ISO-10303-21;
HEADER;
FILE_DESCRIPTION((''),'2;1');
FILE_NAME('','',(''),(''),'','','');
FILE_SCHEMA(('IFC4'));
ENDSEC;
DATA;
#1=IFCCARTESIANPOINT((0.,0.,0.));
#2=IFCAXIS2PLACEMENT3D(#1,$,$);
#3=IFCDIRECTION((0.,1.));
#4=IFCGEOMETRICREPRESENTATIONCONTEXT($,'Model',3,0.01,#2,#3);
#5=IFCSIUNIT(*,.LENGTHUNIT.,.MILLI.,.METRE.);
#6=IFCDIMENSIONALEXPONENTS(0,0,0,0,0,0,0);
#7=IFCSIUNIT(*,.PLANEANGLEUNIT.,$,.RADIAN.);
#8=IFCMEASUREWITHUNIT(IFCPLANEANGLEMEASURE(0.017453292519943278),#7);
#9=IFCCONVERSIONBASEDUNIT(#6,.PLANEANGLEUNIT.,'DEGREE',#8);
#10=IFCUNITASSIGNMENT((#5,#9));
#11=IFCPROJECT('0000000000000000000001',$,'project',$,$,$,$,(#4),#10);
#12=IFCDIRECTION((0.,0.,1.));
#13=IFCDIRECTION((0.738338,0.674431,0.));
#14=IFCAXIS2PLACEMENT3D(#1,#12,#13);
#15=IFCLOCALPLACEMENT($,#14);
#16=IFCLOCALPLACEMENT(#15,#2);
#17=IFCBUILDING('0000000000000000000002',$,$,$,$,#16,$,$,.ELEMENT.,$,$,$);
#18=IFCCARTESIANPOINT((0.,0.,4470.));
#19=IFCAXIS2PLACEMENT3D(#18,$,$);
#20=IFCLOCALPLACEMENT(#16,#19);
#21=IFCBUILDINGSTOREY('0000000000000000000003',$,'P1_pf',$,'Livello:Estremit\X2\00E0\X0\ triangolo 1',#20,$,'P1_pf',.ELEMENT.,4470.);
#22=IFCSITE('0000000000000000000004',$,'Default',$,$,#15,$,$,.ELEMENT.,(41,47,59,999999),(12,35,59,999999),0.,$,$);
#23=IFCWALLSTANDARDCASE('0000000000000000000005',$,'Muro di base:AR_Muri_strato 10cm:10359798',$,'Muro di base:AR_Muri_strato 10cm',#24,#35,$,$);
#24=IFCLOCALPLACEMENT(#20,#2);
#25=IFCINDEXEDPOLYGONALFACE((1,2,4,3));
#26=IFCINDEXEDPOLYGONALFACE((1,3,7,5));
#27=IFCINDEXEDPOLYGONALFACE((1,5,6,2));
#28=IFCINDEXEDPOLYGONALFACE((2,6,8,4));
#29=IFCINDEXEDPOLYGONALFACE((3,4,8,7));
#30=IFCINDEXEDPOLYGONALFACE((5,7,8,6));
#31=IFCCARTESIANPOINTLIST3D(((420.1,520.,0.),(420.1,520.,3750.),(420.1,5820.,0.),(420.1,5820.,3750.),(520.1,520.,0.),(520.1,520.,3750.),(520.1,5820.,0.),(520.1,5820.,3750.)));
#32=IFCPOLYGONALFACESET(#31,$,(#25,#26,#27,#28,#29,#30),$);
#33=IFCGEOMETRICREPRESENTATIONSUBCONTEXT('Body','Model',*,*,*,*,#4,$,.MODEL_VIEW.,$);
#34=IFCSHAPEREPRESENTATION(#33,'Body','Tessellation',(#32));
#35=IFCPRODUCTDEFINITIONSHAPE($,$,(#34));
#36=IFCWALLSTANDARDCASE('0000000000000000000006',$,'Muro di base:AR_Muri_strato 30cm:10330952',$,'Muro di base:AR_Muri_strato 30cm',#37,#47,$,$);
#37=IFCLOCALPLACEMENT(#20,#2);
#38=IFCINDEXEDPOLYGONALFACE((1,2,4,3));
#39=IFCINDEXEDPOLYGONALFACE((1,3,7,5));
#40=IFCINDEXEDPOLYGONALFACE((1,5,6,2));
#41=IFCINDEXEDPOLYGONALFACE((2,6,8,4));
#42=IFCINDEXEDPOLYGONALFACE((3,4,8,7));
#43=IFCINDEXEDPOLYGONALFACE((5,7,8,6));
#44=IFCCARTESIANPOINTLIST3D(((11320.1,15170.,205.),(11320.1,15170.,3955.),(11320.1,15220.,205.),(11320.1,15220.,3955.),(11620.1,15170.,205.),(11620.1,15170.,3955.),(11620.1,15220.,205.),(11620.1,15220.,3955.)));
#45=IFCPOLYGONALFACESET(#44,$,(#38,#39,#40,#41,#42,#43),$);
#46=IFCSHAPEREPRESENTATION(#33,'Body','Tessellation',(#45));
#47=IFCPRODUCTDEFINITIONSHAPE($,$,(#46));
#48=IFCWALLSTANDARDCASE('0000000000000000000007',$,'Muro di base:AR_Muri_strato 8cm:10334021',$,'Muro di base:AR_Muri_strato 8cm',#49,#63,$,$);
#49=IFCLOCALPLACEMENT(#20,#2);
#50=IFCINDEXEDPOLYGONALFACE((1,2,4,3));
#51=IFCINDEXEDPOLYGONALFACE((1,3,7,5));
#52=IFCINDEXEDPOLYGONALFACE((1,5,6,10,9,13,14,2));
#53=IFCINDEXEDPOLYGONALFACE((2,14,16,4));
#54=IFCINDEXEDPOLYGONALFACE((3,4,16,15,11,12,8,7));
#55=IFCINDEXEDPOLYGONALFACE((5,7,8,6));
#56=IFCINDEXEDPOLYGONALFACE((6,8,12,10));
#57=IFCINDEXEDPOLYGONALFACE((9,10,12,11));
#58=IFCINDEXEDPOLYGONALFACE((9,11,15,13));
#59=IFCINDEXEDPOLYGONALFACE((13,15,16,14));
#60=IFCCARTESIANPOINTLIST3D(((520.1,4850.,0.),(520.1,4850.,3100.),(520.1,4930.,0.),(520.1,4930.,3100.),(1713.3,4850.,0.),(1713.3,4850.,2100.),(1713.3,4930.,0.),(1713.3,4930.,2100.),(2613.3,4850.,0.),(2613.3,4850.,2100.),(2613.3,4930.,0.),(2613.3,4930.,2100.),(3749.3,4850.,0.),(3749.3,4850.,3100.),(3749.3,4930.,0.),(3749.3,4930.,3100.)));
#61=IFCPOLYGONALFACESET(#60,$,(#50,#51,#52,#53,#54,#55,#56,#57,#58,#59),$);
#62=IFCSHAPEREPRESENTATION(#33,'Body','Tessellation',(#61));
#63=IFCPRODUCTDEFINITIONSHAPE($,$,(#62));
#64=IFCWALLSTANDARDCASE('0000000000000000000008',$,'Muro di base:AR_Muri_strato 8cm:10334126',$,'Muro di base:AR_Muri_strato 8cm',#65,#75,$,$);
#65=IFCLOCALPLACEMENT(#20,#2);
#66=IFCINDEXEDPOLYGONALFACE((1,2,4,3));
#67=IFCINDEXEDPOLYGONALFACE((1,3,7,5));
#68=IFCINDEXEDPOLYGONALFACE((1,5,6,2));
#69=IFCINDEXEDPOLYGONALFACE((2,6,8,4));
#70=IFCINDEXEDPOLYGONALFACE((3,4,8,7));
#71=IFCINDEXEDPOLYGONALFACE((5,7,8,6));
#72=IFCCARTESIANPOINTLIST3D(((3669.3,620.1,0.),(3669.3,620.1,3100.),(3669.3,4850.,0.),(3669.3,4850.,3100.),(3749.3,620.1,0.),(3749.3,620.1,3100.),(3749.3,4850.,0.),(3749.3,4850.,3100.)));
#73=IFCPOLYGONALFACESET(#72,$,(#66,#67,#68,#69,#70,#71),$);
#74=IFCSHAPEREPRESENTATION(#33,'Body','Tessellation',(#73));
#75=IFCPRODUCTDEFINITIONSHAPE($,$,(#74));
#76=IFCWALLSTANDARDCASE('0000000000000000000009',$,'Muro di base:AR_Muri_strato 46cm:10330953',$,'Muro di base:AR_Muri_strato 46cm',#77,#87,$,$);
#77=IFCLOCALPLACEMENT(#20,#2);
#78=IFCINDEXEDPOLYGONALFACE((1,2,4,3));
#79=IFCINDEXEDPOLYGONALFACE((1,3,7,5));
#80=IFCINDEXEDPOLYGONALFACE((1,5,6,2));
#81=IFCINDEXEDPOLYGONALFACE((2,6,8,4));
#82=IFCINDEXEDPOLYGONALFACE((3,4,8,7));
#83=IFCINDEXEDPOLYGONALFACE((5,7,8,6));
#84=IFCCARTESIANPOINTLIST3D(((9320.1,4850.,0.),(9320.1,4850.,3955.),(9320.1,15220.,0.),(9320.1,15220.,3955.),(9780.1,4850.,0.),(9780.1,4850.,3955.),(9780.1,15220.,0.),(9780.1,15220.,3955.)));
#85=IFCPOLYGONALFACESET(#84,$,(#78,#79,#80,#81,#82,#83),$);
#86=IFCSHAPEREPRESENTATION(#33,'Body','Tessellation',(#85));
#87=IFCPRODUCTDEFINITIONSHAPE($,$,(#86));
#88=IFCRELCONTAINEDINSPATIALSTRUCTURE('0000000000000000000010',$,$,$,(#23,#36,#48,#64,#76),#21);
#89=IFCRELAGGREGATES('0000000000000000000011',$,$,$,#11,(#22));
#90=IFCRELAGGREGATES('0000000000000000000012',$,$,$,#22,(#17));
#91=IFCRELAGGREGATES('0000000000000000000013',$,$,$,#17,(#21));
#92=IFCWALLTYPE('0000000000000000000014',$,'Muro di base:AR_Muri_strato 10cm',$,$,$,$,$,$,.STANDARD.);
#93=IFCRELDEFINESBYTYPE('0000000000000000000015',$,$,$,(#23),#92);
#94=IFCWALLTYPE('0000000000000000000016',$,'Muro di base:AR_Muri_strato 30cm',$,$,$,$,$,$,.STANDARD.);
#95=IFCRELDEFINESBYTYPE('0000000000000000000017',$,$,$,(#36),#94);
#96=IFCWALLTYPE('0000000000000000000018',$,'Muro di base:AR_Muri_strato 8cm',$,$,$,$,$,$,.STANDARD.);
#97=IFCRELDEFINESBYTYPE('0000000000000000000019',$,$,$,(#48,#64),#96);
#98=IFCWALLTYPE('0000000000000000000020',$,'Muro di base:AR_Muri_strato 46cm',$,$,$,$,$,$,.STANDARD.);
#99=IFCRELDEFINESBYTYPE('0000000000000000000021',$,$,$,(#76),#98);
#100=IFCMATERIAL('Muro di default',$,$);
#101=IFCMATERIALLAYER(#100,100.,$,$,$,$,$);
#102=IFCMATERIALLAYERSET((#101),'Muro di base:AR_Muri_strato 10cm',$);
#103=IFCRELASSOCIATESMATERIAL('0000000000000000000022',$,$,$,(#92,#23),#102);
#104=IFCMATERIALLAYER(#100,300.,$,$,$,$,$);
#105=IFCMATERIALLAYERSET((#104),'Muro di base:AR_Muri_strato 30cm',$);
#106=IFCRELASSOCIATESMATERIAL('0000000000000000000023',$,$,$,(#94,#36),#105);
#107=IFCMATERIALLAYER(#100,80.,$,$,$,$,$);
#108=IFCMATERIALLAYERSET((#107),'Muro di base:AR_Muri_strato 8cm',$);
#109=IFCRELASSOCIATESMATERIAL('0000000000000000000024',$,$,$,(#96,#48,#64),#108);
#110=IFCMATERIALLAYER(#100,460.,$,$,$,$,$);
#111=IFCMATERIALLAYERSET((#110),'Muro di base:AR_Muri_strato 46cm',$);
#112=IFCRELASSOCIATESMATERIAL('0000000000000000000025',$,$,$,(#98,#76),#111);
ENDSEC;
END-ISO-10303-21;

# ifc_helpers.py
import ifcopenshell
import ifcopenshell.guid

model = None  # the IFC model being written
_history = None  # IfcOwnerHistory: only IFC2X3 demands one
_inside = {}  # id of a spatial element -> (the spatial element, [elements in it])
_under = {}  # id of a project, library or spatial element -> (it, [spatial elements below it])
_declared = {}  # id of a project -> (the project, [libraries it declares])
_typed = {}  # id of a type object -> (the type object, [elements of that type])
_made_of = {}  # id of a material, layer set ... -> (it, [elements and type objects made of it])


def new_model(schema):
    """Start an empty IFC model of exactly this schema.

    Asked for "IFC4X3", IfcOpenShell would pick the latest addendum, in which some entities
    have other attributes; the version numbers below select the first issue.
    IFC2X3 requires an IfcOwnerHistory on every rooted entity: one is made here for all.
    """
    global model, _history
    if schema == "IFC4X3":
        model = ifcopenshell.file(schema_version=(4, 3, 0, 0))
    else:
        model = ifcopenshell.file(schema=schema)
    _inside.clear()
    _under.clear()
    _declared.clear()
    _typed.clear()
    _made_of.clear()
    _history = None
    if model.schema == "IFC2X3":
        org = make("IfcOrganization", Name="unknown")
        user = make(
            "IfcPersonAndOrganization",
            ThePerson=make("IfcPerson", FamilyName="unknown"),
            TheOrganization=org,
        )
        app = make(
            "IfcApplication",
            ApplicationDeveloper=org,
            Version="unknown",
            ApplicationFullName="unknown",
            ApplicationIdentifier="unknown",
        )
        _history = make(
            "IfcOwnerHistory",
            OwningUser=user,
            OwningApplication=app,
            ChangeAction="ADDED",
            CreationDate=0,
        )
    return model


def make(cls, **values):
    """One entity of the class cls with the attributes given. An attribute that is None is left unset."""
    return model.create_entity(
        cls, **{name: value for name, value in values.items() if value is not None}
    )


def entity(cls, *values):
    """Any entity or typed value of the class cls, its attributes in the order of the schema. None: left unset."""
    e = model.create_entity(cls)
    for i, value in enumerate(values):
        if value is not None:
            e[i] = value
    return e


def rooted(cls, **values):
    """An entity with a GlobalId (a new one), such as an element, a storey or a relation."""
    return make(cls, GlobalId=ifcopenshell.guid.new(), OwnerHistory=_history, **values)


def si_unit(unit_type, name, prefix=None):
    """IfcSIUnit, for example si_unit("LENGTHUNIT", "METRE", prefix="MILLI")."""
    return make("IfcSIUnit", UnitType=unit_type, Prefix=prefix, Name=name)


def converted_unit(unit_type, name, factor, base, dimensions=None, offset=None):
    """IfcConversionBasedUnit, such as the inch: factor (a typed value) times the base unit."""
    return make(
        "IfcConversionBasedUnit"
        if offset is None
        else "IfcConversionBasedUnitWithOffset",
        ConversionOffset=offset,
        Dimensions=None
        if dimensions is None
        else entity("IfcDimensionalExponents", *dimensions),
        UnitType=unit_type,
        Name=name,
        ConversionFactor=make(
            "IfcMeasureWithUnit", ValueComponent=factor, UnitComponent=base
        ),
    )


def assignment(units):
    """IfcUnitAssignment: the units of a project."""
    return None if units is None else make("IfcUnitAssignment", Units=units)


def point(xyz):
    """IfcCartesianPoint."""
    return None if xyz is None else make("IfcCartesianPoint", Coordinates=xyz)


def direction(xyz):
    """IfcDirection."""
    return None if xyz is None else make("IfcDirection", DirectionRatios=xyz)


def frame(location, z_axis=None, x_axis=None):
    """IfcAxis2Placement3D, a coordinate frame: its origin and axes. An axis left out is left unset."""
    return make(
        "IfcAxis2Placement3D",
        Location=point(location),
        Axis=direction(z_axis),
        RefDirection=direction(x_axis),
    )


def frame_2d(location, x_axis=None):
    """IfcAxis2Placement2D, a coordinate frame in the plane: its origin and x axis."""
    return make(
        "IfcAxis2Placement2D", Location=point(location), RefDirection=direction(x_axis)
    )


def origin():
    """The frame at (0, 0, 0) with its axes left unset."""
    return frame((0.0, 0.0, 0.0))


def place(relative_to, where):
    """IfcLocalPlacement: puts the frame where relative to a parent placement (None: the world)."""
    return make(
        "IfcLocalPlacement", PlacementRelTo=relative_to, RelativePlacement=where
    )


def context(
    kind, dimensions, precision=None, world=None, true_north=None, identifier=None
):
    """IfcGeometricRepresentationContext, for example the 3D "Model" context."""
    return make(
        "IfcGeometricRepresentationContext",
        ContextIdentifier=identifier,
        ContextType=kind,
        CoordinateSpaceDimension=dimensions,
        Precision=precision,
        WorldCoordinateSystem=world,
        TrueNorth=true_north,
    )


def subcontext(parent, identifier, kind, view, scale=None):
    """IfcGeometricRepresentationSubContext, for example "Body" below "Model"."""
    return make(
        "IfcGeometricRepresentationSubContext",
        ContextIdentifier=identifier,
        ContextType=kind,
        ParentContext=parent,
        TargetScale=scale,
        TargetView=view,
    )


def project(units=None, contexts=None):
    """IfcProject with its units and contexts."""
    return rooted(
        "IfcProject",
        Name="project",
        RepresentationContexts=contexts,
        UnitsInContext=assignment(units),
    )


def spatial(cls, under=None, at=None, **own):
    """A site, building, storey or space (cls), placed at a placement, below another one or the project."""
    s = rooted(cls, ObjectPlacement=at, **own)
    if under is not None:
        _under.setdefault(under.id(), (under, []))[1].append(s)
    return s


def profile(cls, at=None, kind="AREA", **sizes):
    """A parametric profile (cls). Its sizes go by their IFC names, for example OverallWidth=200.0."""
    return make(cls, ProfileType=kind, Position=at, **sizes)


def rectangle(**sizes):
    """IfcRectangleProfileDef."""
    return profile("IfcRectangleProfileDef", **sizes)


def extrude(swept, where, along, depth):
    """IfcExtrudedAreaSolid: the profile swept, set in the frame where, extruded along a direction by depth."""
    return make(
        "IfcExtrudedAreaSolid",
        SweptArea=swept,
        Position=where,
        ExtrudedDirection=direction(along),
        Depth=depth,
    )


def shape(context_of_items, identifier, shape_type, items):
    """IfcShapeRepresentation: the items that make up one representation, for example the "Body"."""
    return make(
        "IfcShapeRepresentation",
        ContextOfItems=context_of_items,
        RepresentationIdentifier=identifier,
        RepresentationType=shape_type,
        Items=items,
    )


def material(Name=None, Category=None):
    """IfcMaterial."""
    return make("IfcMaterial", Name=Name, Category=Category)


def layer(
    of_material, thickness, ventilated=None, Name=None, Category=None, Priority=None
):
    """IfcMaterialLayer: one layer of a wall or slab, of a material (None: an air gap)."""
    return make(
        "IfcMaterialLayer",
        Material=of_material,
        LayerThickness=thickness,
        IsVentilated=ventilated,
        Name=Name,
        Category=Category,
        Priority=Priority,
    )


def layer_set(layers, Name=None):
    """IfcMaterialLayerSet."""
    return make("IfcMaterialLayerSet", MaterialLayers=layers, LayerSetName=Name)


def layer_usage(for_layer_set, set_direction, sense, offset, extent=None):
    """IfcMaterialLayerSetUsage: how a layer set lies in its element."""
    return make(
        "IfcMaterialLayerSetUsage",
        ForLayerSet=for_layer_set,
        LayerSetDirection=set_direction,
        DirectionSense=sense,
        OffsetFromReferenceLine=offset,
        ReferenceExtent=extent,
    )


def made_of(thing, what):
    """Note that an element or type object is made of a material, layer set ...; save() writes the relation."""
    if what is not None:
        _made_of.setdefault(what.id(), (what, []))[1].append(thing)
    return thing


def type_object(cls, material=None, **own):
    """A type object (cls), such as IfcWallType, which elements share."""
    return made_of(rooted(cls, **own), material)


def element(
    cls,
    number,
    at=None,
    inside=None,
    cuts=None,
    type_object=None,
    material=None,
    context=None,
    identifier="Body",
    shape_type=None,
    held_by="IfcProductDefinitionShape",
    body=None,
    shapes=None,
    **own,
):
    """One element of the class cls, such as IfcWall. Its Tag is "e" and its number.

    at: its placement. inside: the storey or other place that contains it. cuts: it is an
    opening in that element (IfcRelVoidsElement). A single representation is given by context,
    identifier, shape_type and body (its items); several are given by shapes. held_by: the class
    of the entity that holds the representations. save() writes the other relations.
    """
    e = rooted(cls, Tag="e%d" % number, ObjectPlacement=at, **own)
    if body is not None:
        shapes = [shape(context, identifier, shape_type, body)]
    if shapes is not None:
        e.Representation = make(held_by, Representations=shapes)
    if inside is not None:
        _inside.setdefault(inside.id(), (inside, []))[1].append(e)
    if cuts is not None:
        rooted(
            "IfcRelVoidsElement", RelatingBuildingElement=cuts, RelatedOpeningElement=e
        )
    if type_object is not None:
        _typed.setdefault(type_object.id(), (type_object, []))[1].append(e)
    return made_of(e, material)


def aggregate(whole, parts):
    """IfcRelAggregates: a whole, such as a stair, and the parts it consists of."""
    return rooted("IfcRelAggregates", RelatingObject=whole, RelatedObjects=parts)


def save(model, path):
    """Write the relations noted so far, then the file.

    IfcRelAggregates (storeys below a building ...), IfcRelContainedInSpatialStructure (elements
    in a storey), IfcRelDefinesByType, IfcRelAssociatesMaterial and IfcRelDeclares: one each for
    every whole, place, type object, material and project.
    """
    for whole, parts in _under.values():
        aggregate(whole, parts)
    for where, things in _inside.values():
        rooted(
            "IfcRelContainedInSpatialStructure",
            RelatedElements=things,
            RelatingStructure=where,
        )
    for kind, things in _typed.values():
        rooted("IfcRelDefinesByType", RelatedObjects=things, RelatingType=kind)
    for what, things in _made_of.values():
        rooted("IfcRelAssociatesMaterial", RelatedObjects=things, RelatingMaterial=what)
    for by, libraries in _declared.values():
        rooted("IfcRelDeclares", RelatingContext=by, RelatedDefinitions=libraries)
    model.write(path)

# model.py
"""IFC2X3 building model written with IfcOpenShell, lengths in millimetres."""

from ifc_helpers import new_model, entity, si_unit, converted_unit, direction, frame, frame_2d, origin, place, context, subcontext, project, spatial, rectangle, extrude, material, layer, layer_set, layer_usage, type_object, element, save


model = new_model("IFC2X3")

# Units and contexts
model_context = context("Model", 3, precision=0.01, world=origin(), true_north=direction((0.0, 1.0)))
body_context = subcontext(model_context, "Body", "Model", "MODEL_VIEW")
ifc_project = project(units=[si_unit("LENGTHUNIT", "METRE", prefix="MILLI"), converted_unit("PLANEANGLEUNIT", "DEGREE", entity("IfcPlaneAngleMeasure", 0.017453292519943278), si_unit("PLANEANGLEUNIT", "RADIAN"), dimensions=[0, 0, 0, 0, 0, 0, 0])], contexts=[model_context])

# Site, building, storey
site_placement = place(None, frame((0.0, 0.0, 0.0), z_axis=(0.0, 0.0, 1.0), x_axis=(0.738338, 0.674431, 0.0)))
site = spatial("IfcSite", under=ifc_project, at=site_placement, Name="Default", CompositionType="ELEMENT", RefLatitude=(41, 47, 59, 999999), RefLongitude=(12, 35, 59, 999999), RefElevation=0.0)
building_placement = place(site_placement, origin())
building = spatial("IfcBuilding", under=site, at=building_placement, CompositionType="ELEMENT")
storey_placement = place(building_placement, frame((0.0, 0.0, 4470.0)))
storey = spatial("IfcBuildingStorey", under=building, at=storey_placement, Name="P1_pf", ObjectType="Livello:Estremità triangolo 1", LongName="P1_pf", CompositionType="ELEMENT", Elevation=4470.0)

# Walls
ifc_material_1 = material(Name="Muro di default")
ifc_layer_1 = layer(ifc_material_1, 100.0)
ifc_layer_set_1 = layer_set([ifc_layer_1], Name="Muro di base:AR_Muri_strato 10cm")
wall_type_1 = type_object("IfcWallType", Name="Muro di base:AR_Muri_strato 10cm", PredefinedType="STANDARD", material=ifc_layer_set_1)
ifc_layer_usage_1 = layer_usage(ifc_layer_set_1, "AXIS2", "NEGATIVE", 50.0)
wall_1_placement = place(storey_placement, frame((470.1, 520.0, 0.0), z_axis=(0.0, 0.0, 1.0), x_axis=(0.0, 1.0, 0.0)))
element("IfcWallStandardCase", 1, at=wall_1_placement, inside=storey, type_object=wall_type_1, material=ifc_layer_usage_1, Name="Muro di base:AR_Muri_strato 10cm:10359798", ObjectType="Muro di base:AR_Muri_strato 10cm", context=body_context, shape_type="SweptSolid", body=[
    extrude(rectangle(XDim=5300.0, YDim=100.0, at=frame_2d((2650.0, 0.0), x_axis=(-1.0, 0.0))), origin(), (0.0, 0.0, 1.0), 3750.0),
])
ifc_layer_2 = layer(ifc_material_1, 300.0)
ifc_layer_set_2 = layer_set([ifc_layer_2], Name="Muro di base:AR_Muri_strato 30cm")
ifc_layer_usage_2 = layer_usage(ifc_layer_set_2, "AXIS2", "NEGATIVE", 150.0)
wall_type_2 = type_object("IfcWallType", Name="Muro di base:AR_Muri_strato 30cm", PredefinedType="STANDARD", material=ifc_layer_set_2)
wall_2_placement = place(storey_placement, frame((11470.1, 15170.0, 205.0), z_axis=(0.0, 0.0, 1.0), x_axis=(0.0, 1.0, 0.0)))
element("IfcWallStandardCase", 2, at=wall_2_placement, inside=storey, type_object=wall_type_2, material=ifc_layer_usage_2, Name="Muro di base:AR_Muri_strato 30cm:10330952", ObjectType="Muro di base:AR_Muri_strato 30cm", context=body_context, shape_type="SweptSolid", body=[
    extrude(rectangle(XDim=50.0, YDim=300.0, at=frame_2d((25.0, 0.0), x_axis=(-1.0, 0.0))), origin(), (0.0, 0.0, 1.0), 3750.0),
])

# Wall, opening
ifc_layer_3 = layer(ifc_material_1, 80.0)
ifc_layer_set_3 = layer_set([ifc_layer_3], Name="Muro di base:AR_Muri_strato 8cm")
ifc_layer_usage_3 = layer_usage(ifc_layer_set_3, "AXIS2", "NEGATIVE", 40.0)
wall_type_3 = type_object("IfcWallType", Name="Muro di base:AR_Muri_strato 8cm", PredefinedType="STANDARD", material=ifc_layer_set_3)
wall_3_placement = place(storey_placement, frame((520.1, 4890.0, 0.0)))
wall_3 = element("IfcWallStandardCase", 3, at=wall_3_placement, inside=storey, type_object=wall_type_3, material=ifc_layer_usage_3, Name="Muro di base:AR_Muri_strato 8cm:10334021", ObjectType="Muro di base:AR_Muri_strato 8cm", context=body_context, shape_type="SweptSolid", body=[
    extrude(rectangle(XDim=3229.2, YDim=80.0, at=frame_2d((1614.6, 0.0), x_axis=(1.0, 0.0))), origin(), (0.0, 0.0, 1.0), 3100.0),
])
opening_placement = place(wall_3_placement, frame((-520.1, -4890.0, 0.0)))
element("IfcOpeningElement", 4, at=opening_placement, cuts=wall_3, ObjectType="Opening", context=body_context, shape_type="SweptSolid", body=[
    extrude(rectangle(XDim=2100.0, YDim=900.0, at=frame_2d((0.0, 0.0), x_axis=(1.0, 0.0))), frame((2163.3, 3406.0, 1050.0), z_axis=(0.0, 1.0, 0.0), x_axis=(0.0, 0.0, -1.0)), (0.0, 0.0, 1.0), 3048.0),
])

# Walls
ifc_layer_usage_4 = layer_usage(ifc_layer_set_3, "AXIS2", "NEGATIVE", 40.0)
wall_4_placement = place(storey_placement, frame((3709.3, 4850.0, 0.0), z_axis=(0.0, 0.0, 1.0), x_axis=(0.0, -1.0, 0.0)))
element("IfcWallStandardCase", 5, at=wall_4_placement, inside=storey, type_object=wall_type_3, material=ifc_layer_usage_4, Name="Muro di base:AR_Muri_strato 8cm:10334126", ObjectType="Muro di base:AR_Muri_strato 8cm", context=body_context, shape_type="SweptSolid", body=[
    extrude(rectangle(XDim=4229.9, YDim=80.0, at=frame_2d((2114.9, 0.0), x_axis=(-1.0, 0.0))), origin(), (0.0, 0.0, 1.0), 3100.0),
])
ifc_layer_4 = layer(ifc_material_1, 460.0)
ifc_layer_set_4 = layer_set([ifc_layer_4], Name="Muro di base:AR_Muri_strato 46cm")
ifc_layer_usage_5 = layer_usage(ifc_layer_set_4, "AXIS2", "NEGATIVE", 230.0)
wall_type_4 = type_object("IfcWallType", Name="Muro di base:AR_Muri_strato 46cm", PredefinedType="STANDARD", material=ifc_layer_set_4)
wall_5_placement = place(storey_placement, frame((9550.1, 15220.0, 0.0), z_axis=(0.0, 0.0, 1.0), x_axis=(0.0, -1.0, 0.0)))
element("IfcWallStandardCase", 6, at=wall_5_placement, inside=storey, type_object=wall_type_4, material=ifc_layer_usage_5, Name="Muro di base:AR_Muri_strato 46cm:10330953", ObjectType="Muro di base:AR_Muri_strato 46cm", context=body_context, shape_type="SweptSolid", body=[
    extrude(rectangle(XDim=10370.0, YDim=460.0, at=frame_2d((5185.0, 0.0), x_axis=(-1.0, 0.0))), origin(), (0.0, 0.0, 1.0), 3955.0),
])

save(model, "model.ifc")
